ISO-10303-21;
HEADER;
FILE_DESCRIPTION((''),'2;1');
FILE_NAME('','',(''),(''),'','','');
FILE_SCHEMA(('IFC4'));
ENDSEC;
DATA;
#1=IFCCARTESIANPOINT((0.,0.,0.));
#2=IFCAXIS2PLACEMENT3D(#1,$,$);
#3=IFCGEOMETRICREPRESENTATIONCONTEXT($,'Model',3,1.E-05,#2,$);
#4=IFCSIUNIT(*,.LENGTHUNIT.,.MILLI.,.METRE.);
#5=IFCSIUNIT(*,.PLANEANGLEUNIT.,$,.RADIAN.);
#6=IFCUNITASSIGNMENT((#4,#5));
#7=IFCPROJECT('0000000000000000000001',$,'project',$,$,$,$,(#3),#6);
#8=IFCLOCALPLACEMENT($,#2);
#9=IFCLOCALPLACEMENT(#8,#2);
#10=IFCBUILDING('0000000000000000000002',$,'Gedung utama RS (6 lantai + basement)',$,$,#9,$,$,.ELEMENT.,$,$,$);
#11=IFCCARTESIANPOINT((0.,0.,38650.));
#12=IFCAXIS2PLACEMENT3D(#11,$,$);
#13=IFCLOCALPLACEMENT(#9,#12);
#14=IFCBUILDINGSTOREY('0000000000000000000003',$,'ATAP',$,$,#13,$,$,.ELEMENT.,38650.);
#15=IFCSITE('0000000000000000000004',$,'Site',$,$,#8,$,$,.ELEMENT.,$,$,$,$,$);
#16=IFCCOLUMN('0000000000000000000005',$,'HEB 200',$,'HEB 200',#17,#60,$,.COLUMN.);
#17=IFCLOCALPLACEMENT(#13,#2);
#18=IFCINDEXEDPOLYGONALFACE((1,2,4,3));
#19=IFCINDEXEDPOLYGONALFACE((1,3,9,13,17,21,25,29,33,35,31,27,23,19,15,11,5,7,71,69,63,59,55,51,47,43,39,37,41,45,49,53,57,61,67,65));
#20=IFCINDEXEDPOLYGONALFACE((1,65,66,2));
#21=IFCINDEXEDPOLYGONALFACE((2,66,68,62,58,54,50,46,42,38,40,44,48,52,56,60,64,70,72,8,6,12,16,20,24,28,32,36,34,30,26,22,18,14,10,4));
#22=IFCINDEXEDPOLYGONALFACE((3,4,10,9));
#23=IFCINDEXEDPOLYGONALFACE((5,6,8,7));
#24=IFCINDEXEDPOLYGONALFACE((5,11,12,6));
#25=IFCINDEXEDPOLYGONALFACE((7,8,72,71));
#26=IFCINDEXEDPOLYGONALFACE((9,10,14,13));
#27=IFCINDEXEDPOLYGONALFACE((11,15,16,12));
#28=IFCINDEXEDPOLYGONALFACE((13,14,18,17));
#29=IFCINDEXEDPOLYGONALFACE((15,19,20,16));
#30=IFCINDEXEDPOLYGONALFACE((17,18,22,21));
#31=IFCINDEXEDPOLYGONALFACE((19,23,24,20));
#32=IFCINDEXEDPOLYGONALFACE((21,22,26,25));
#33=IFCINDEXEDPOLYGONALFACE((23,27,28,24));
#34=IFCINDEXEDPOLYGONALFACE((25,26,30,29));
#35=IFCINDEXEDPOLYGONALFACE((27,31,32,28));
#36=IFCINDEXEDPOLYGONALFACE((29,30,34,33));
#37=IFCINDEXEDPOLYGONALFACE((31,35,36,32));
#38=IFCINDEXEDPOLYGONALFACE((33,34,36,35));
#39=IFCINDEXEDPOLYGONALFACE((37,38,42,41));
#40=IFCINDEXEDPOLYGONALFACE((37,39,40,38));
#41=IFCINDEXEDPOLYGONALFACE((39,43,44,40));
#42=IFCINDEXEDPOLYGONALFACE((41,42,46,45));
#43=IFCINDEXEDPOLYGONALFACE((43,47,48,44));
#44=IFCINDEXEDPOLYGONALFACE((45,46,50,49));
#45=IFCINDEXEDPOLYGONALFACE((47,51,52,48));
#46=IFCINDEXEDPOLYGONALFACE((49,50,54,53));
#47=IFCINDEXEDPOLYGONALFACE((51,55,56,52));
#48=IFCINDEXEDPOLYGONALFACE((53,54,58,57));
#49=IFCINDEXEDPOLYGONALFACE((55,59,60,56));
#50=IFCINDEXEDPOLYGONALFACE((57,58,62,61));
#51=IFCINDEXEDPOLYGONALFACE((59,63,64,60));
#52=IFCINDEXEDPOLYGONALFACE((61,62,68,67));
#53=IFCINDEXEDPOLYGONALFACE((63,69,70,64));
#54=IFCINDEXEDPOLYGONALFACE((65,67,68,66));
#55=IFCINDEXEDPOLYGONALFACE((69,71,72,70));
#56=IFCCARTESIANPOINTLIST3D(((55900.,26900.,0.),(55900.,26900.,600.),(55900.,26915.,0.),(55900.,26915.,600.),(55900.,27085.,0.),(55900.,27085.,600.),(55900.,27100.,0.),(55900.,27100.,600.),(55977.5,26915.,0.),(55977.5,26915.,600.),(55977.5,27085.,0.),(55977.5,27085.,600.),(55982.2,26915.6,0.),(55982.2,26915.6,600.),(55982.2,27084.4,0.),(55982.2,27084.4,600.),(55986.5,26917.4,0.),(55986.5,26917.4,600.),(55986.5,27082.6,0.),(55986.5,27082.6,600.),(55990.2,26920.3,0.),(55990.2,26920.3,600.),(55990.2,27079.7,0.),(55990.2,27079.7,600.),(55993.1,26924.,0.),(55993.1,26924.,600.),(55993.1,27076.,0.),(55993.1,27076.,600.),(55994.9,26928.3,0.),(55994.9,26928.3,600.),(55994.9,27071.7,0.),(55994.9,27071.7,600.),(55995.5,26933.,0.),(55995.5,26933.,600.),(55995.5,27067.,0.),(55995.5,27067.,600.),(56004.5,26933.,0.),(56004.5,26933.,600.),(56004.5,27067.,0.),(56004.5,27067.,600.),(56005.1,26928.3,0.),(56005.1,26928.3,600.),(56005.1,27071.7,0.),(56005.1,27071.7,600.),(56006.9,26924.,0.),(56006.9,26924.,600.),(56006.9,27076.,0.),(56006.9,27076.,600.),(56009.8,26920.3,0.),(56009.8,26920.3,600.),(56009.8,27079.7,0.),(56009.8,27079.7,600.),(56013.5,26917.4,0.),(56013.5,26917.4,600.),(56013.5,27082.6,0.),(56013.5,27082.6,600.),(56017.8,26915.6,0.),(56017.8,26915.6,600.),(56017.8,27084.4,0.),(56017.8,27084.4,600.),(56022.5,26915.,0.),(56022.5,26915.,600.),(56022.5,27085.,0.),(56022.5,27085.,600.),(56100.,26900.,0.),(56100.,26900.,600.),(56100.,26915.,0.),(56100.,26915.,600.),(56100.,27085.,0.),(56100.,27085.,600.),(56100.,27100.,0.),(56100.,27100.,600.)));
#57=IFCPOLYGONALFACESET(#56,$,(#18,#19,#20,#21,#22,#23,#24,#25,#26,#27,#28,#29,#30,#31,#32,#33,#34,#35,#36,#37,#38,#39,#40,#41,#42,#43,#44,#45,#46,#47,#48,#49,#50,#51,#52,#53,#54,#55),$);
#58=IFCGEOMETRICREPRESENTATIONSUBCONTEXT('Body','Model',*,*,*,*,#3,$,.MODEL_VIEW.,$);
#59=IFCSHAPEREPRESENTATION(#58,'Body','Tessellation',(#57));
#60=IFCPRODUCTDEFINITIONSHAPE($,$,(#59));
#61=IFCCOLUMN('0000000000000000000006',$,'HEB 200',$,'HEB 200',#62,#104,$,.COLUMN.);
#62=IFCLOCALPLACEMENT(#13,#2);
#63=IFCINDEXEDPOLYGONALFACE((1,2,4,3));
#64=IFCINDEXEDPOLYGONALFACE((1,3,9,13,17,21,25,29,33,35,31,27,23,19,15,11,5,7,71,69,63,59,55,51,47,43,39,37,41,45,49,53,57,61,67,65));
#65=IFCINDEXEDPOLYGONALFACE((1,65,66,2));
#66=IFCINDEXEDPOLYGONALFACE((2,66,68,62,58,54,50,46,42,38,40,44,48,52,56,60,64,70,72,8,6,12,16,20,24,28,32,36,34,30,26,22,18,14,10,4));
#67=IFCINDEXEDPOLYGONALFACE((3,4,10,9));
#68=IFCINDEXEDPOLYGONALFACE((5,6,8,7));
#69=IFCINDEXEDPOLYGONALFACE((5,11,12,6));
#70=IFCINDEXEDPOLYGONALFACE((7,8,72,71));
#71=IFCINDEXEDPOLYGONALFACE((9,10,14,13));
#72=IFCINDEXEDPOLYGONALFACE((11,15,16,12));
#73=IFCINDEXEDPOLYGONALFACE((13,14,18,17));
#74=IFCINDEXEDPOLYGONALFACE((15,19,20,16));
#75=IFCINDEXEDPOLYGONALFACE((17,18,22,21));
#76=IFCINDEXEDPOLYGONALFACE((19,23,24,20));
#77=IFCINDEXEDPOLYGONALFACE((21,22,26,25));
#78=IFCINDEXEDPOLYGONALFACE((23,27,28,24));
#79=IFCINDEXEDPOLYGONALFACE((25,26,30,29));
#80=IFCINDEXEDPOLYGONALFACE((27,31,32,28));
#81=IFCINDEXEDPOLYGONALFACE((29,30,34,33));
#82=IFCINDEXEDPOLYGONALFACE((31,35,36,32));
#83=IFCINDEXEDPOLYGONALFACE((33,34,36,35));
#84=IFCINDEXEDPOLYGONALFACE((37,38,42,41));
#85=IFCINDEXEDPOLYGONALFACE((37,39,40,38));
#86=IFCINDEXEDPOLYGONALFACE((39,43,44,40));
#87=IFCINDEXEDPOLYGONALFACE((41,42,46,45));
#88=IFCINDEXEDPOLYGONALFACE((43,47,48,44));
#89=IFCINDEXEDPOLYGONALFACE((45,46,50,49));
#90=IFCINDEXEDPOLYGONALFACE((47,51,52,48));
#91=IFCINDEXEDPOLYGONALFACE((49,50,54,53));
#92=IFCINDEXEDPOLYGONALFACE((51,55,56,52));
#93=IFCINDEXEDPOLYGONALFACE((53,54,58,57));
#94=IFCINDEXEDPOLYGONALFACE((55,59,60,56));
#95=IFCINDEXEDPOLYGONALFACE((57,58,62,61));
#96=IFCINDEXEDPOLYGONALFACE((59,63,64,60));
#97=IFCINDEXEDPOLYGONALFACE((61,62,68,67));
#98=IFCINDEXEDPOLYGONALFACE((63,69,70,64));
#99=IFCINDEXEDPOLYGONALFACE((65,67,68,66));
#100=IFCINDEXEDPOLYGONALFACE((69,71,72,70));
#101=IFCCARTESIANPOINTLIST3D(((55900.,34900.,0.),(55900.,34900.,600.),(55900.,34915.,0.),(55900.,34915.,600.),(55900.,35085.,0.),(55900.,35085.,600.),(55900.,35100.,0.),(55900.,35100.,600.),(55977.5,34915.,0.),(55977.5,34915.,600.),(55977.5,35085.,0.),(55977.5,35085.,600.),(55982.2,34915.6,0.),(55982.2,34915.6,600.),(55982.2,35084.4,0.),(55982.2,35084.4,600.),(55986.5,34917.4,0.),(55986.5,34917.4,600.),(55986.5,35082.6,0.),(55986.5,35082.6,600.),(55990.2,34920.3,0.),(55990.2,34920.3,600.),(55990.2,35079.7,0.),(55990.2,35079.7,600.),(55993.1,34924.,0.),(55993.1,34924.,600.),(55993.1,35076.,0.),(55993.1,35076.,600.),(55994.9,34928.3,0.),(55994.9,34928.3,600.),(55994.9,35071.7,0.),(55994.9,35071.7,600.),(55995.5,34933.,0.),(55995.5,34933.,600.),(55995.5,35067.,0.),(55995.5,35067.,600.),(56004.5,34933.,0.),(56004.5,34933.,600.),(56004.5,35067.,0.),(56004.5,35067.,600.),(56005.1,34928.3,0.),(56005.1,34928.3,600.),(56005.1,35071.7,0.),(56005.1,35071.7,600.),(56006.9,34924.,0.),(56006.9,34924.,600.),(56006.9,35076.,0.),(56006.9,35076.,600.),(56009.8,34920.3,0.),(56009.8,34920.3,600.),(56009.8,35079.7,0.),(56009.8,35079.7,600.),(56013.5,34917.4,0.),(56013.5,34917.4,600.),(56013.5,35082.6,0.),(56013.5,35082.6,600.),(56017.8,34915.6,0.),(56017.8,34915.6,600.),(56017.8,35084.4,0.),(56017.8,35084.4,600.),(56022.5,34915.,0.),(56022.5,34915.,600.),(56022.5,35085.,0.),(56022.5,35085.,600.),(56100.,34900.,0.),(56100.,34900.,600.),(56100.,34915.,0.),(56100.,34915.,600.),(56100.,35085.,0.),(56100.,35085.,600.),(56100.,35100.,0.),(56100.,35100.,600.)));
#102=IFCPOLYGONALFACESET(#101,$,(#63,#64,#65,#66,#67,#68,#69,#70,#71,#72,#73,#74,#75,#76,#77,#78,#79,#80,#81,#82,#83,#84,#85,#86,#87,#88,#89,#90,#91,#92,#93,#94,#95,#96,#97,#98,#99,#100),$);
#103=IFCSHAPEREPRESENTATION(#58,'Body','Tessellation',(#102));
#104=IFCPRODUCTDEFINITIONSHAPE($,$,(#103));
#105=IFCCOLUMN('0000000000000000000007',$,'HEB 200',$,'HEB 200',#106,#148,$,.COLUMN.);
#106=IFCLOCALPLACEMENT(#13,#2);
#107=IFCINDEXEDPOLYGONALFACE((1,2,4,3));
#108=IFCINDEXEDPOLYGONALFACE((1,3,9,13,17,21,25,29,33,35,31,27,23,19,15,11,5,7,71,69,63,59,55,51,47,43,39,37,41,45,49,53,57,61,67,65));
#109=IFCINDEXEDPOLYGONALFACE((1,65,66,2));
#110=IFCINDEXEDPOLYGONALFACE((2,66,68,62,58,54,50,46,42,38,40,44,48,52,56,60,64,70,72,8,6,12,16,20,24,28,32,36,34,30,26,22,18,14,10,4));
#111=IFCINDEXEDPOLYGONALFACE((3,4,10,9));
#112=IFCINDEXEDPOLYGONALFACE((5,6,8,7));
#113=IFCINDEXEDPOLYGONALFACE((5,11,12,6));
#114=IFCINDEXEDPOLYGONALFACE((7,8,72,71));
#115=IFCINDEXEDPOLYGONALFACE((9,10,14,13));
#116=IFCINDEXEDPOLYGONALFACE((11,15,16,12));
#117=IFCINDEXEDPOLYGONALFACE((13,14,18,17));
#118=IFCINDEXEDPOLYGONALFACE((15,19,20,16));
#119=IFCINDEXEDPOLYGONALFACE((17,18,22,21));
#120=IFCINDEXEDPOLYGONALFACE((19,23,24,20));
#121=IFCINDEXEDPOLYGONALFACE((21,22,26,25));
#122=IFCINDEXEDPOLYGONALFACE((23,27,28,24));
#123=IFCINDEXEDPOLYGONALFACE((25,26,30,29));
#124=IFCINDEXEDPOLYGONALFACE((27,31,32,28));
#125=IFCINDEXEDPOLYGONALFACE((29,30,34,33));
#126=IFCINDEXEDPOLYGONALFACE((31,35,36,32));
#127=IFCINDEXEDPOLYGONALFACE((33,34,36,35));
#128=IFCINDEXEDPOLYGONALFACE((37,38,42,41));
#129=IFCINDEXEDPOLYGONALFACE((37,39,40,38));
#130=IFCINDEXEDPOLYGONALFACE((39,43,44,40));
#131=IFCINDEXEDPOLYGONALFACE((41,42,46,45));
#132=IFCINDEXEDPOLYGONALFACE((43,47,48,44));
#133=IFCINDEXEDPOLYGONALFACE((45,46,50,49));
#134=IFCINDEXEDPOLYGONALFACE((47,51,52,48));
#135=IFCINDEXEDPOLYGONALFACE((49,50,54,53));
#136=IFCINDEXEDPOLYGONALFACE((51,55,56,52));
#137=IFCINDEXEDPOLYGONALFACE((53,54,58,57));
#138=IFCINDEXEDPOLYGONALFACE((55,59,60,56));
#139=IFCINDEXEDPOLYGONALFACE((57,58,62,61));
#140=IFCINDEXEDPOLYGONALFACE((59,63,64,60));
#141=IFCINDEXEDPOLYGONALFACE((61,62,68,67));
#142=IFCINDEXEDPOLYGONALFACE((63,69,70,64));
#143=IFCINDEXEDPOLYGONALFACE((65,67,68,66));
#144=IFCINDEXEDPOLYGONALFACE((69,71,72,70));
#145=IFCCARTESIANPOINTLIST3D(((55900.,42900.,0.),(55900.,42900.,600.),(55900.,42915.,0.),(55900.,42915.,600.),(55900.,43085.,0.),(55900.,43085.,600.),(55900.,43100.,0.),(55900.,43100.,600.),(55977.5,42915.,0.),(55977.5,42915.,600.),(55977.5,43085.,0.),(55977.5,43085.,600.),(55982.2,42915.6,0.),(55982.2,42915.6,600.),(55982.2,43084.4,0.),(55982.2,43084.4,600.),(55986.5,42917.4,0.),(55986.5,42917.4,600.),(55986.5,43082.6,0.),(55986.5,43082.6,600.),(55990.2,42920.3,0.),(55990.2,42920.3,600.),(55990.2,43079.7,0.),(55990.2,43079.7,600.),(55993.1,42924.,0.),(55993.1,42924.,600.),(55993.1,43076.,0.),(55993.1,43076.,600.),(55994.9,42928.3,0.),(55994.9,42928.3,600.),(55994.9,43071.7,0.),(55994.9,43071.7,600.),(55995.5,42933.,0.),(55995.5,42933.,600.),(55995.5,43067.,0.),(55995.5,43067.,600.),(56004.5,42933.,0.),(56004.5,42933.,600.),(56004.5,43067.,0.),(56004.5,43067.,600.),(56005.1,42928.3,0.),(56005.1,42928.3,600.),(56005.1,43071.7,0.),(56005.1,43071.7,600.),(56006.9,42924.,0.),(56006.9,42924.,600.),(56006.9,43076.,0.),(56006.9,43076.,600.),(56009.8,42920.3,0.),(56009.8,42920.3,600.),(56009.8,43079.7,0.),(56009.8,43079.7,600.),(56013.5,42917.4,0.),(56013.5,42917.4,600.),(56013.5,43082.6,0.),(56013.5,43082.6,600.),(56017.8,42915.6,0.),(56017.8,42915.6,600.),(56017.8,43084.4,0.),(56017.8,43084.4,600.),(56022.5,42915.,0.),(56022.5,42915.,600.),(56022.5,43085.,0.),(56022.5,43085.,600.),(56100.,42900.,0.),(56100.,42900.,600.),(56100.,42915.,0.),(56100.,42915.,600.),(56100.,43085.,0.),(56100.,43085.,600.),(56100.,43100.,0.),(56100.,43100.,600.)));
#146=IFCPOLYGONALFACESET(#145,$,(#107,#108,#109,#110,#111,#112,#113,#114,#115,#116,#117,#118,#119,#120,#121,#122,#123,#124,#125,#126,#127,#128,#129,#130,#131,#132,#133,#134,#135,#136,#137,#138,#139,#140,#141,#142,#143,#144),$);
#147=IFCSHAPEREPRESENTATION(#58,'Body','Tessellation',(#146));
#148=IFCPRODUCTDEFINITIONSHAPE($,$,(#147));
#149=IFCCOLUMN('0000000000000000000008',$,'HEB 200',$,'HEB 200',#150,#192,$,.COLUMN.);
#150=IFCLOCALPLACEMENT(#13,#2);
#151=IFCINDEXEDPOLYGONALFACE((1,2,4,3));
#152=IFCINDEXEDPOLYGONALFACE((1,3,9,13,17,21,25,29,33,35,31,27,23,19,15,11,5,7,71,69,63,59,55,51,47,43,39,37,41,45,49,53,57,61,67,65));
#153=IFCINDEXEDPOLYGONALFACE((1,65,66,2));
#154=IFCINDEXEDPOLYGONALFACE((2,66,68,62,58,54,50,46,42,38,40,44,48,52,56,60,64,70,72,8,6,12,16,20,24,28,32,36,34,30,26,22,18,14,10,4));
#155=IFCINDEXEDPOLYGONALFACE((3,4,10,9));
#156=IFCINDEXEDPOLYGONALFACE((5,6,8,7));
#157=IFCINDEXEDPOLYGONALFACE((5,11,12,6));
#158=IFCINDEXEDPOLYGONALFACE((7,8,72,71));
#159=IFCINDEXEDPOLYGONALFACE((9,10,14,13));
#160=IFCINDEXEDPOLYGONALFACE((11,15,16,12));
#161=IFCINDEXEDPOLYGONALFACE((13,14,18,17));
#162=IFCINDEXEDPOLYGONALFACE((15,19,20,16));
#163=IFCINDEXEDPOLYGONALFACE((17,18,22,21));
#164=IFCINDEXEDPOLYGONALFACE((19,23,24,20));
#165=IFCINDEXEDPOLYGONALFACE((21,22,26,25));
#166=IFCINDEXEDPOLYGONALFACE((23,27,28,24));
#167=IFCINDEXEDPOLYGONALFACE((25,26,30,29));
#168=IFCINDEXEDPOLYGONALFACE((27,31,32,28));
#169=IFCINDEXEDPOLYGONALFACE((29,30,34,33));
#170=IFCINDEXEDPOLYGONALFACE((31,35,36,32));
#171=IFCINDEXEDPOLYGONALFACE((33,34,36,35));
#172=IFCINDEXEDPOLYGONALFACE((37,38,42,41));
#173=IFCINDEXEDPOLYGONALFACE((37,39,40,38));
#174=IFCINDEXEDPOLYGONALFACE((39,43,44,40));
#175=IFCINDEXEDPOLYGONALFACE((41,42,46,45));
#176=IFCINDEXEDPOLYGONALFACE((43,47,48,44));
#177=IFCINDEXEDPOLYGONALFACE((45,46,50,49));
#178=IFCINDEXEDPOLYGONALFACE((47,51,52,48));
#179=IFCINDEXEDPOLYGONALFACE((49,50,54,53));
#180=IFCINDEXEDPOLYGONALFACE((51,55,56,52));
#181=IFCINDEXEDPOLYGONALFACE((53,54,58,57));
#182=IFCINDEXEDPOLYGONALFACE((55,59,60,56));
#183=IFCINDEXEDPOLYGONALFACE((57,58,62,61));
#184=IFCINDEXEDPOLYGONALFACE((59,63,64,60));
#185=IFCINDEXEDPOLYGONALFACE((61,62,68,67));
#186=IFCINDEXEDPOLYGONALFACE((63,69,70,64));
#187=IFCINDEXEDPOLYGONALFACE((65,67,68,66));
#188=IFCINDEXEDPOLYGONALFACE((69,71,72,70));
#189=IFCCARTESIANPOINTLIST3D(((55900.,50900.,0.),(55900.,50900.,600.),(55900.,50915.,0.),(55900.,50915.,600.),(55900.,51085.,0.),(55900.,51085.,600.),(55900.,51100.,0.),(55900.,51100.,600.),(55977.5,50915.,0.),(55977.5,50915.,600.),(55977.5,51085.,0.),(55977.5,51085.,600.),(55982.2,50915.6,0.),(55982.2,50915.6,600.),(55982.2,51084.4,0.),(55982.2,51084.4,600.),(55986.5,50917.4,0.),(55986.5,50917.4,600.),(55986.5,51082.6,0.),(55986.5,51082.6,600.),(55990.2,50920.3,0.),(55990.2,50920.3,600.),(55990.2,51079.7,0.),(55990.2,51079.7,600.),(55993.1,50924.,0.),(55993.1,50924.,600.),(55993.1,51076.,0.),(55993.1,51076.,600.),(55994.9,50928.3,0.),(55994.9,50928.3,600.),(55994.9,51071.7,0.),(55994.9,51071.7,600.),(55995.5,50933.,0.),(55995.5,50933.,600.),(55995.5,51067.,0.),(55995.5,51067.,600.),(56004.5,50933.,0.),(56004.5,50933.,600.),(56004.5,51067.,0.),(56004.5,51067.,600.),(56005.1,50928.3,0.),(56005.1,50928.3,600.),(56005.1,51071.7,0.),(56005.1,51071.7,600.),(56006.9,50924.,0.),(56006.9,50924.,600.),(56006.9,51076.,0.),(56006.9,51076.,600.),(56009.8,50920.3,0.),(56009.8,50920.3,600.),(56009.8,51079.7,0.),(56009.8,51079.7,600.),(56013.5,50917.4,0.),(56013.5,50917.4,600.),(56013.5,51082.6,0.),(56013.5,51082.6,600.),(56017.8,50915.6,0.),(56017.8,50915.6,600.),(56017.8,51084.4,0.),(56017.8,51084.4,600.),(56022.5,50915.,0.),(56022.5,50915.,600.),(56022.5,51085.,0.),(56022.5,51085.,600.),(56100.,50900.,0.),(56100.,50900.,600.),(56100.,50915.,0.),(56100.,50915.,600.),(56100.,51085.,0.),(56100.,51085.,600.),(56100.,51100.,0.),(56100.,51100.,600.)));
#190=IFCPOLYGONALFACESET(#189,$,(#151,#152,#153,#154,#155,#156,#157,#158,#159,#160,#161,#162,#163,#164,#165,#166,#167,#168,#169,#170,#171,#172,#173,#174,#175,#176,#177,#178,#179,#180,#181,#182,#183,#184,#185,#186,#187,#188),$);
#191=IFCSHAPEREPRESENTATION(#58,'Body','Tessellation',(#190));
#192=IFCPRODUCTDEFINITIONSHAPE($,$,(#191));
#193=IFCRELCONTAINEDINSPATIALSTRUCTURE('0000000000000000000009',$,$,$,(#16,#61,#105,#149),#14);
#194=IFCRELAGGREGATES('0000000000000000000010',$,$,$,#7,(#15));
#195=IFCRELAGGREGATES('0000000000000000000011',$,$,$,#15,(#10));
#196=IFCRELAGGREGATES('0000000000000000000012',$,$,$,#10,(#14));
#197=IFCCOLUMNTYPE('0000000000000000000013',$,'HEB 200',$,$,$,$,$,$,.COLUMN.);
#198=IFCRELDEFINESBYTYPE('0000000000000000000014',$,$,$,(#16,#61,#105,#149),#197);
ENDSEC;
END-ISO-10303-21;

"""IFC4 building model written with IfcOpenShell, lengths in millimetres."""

from ifc_helpers import new_model, si_unit, frame, origin, origin_2d, place, context, subcontext, project, spatial, i_section, extrude, material_profile, profile_set, profile_usage, type_object, element, save


model = new_model("IFC4")

# Units and contexts
model_context = context("Model", 3, precision=1e-05, world=origin())
body_context = subcontext(model_context, "Body", "Model", "MODEL_VIEW")
ifc_project = project(units=[si_unit("LENGTHUNIT", "METRE", prefix="MILLI"), si_unit("PLANEANGLEUNIT", "RADIAN")], contexts=[model_context])

# Site, building, storey
site_placement = place(None, origin())
site = spatial("IfcSite", under=ifc_project, at=site_placement, Name="Site", CompositionType="ELEMENT")
building_placement = place(site_placement, origin())
building = spatial("IfcBuilding", under=site, at=building_placement, Name="Gedung utama RS (6 lantai + basement)", CompositionType="ELEMENT")
storey_placement = place(building_placement, frame((0.0, 0.0, 38650.0)))
storey = spatial("IfcBuildingStorey", under=building, at=storey_placement, Name="ATAP", CompositionType="ELEMENT", Elevation=38650.0)

# Columns
ifc_material_profile_1 = material_profile(None, i_section(OverallWidth=200.0, OverallDepth=200.0, WebThickness=9.0, FlangeThickness=15.0, FilletRadius=18.0, at=origin_2d()), Name="HEB 200")
ifc_profile_set_1 = profile_set([ifc_material_profile_1], Name="HEB 200")
ifc_profile_usage_1 = profile_usage(ifc_profile_set_1, cardinal=5)
column_type = type_object("IfcColumnType", Name="HEB 200", PredefinedType="COLUMN", material=ifc_profile_set_1)
for number, where, z_axis, x_axis, name in (
    (1, (56000.0, 27000.0, 0.0), (0.0, 0.0, 1.0), (1.0, 0.0, 0.0), "HEB 200"),
    (2, (56000.0, 35000.0, 0.0), (0.0, 0.0, 1.0), (1.0, 0.0, 0.0), "HEB 200"),
    (3, (56000.0, 43000.0, 0.0), (0.0, 0.0, 1.0), (1.0, 0.0, 0.0), "HEB 200"),
    (4, (56000.0, 51000.0, 0.0), (0.0, 0.0, 1.0), (1.0, 0.0, 0.0), "HEB 200"),
):
    element("IfcColumn", number, at=place(storey_placement, frame(where, z_axis=z_axis, x_axis=x_axis)), inside=storey, type_object=column_type, material=ifc_profile_usage_1, Name=name, ObjectType="HEB 200", PredefinedType="COLUMN", context=body_context, shape_type="SweptSolid", body=[
        extrude(i_section(OverallWidth=200.0, OverallDepth=200.0, WebThickness=9.0, FlangeThickness=15.0, FilletRadius=18.0, at=origin_2d()), origin(), (0.0, 0.0, 1.0), 600.0),
    ])

save(model, "model.ifc")
